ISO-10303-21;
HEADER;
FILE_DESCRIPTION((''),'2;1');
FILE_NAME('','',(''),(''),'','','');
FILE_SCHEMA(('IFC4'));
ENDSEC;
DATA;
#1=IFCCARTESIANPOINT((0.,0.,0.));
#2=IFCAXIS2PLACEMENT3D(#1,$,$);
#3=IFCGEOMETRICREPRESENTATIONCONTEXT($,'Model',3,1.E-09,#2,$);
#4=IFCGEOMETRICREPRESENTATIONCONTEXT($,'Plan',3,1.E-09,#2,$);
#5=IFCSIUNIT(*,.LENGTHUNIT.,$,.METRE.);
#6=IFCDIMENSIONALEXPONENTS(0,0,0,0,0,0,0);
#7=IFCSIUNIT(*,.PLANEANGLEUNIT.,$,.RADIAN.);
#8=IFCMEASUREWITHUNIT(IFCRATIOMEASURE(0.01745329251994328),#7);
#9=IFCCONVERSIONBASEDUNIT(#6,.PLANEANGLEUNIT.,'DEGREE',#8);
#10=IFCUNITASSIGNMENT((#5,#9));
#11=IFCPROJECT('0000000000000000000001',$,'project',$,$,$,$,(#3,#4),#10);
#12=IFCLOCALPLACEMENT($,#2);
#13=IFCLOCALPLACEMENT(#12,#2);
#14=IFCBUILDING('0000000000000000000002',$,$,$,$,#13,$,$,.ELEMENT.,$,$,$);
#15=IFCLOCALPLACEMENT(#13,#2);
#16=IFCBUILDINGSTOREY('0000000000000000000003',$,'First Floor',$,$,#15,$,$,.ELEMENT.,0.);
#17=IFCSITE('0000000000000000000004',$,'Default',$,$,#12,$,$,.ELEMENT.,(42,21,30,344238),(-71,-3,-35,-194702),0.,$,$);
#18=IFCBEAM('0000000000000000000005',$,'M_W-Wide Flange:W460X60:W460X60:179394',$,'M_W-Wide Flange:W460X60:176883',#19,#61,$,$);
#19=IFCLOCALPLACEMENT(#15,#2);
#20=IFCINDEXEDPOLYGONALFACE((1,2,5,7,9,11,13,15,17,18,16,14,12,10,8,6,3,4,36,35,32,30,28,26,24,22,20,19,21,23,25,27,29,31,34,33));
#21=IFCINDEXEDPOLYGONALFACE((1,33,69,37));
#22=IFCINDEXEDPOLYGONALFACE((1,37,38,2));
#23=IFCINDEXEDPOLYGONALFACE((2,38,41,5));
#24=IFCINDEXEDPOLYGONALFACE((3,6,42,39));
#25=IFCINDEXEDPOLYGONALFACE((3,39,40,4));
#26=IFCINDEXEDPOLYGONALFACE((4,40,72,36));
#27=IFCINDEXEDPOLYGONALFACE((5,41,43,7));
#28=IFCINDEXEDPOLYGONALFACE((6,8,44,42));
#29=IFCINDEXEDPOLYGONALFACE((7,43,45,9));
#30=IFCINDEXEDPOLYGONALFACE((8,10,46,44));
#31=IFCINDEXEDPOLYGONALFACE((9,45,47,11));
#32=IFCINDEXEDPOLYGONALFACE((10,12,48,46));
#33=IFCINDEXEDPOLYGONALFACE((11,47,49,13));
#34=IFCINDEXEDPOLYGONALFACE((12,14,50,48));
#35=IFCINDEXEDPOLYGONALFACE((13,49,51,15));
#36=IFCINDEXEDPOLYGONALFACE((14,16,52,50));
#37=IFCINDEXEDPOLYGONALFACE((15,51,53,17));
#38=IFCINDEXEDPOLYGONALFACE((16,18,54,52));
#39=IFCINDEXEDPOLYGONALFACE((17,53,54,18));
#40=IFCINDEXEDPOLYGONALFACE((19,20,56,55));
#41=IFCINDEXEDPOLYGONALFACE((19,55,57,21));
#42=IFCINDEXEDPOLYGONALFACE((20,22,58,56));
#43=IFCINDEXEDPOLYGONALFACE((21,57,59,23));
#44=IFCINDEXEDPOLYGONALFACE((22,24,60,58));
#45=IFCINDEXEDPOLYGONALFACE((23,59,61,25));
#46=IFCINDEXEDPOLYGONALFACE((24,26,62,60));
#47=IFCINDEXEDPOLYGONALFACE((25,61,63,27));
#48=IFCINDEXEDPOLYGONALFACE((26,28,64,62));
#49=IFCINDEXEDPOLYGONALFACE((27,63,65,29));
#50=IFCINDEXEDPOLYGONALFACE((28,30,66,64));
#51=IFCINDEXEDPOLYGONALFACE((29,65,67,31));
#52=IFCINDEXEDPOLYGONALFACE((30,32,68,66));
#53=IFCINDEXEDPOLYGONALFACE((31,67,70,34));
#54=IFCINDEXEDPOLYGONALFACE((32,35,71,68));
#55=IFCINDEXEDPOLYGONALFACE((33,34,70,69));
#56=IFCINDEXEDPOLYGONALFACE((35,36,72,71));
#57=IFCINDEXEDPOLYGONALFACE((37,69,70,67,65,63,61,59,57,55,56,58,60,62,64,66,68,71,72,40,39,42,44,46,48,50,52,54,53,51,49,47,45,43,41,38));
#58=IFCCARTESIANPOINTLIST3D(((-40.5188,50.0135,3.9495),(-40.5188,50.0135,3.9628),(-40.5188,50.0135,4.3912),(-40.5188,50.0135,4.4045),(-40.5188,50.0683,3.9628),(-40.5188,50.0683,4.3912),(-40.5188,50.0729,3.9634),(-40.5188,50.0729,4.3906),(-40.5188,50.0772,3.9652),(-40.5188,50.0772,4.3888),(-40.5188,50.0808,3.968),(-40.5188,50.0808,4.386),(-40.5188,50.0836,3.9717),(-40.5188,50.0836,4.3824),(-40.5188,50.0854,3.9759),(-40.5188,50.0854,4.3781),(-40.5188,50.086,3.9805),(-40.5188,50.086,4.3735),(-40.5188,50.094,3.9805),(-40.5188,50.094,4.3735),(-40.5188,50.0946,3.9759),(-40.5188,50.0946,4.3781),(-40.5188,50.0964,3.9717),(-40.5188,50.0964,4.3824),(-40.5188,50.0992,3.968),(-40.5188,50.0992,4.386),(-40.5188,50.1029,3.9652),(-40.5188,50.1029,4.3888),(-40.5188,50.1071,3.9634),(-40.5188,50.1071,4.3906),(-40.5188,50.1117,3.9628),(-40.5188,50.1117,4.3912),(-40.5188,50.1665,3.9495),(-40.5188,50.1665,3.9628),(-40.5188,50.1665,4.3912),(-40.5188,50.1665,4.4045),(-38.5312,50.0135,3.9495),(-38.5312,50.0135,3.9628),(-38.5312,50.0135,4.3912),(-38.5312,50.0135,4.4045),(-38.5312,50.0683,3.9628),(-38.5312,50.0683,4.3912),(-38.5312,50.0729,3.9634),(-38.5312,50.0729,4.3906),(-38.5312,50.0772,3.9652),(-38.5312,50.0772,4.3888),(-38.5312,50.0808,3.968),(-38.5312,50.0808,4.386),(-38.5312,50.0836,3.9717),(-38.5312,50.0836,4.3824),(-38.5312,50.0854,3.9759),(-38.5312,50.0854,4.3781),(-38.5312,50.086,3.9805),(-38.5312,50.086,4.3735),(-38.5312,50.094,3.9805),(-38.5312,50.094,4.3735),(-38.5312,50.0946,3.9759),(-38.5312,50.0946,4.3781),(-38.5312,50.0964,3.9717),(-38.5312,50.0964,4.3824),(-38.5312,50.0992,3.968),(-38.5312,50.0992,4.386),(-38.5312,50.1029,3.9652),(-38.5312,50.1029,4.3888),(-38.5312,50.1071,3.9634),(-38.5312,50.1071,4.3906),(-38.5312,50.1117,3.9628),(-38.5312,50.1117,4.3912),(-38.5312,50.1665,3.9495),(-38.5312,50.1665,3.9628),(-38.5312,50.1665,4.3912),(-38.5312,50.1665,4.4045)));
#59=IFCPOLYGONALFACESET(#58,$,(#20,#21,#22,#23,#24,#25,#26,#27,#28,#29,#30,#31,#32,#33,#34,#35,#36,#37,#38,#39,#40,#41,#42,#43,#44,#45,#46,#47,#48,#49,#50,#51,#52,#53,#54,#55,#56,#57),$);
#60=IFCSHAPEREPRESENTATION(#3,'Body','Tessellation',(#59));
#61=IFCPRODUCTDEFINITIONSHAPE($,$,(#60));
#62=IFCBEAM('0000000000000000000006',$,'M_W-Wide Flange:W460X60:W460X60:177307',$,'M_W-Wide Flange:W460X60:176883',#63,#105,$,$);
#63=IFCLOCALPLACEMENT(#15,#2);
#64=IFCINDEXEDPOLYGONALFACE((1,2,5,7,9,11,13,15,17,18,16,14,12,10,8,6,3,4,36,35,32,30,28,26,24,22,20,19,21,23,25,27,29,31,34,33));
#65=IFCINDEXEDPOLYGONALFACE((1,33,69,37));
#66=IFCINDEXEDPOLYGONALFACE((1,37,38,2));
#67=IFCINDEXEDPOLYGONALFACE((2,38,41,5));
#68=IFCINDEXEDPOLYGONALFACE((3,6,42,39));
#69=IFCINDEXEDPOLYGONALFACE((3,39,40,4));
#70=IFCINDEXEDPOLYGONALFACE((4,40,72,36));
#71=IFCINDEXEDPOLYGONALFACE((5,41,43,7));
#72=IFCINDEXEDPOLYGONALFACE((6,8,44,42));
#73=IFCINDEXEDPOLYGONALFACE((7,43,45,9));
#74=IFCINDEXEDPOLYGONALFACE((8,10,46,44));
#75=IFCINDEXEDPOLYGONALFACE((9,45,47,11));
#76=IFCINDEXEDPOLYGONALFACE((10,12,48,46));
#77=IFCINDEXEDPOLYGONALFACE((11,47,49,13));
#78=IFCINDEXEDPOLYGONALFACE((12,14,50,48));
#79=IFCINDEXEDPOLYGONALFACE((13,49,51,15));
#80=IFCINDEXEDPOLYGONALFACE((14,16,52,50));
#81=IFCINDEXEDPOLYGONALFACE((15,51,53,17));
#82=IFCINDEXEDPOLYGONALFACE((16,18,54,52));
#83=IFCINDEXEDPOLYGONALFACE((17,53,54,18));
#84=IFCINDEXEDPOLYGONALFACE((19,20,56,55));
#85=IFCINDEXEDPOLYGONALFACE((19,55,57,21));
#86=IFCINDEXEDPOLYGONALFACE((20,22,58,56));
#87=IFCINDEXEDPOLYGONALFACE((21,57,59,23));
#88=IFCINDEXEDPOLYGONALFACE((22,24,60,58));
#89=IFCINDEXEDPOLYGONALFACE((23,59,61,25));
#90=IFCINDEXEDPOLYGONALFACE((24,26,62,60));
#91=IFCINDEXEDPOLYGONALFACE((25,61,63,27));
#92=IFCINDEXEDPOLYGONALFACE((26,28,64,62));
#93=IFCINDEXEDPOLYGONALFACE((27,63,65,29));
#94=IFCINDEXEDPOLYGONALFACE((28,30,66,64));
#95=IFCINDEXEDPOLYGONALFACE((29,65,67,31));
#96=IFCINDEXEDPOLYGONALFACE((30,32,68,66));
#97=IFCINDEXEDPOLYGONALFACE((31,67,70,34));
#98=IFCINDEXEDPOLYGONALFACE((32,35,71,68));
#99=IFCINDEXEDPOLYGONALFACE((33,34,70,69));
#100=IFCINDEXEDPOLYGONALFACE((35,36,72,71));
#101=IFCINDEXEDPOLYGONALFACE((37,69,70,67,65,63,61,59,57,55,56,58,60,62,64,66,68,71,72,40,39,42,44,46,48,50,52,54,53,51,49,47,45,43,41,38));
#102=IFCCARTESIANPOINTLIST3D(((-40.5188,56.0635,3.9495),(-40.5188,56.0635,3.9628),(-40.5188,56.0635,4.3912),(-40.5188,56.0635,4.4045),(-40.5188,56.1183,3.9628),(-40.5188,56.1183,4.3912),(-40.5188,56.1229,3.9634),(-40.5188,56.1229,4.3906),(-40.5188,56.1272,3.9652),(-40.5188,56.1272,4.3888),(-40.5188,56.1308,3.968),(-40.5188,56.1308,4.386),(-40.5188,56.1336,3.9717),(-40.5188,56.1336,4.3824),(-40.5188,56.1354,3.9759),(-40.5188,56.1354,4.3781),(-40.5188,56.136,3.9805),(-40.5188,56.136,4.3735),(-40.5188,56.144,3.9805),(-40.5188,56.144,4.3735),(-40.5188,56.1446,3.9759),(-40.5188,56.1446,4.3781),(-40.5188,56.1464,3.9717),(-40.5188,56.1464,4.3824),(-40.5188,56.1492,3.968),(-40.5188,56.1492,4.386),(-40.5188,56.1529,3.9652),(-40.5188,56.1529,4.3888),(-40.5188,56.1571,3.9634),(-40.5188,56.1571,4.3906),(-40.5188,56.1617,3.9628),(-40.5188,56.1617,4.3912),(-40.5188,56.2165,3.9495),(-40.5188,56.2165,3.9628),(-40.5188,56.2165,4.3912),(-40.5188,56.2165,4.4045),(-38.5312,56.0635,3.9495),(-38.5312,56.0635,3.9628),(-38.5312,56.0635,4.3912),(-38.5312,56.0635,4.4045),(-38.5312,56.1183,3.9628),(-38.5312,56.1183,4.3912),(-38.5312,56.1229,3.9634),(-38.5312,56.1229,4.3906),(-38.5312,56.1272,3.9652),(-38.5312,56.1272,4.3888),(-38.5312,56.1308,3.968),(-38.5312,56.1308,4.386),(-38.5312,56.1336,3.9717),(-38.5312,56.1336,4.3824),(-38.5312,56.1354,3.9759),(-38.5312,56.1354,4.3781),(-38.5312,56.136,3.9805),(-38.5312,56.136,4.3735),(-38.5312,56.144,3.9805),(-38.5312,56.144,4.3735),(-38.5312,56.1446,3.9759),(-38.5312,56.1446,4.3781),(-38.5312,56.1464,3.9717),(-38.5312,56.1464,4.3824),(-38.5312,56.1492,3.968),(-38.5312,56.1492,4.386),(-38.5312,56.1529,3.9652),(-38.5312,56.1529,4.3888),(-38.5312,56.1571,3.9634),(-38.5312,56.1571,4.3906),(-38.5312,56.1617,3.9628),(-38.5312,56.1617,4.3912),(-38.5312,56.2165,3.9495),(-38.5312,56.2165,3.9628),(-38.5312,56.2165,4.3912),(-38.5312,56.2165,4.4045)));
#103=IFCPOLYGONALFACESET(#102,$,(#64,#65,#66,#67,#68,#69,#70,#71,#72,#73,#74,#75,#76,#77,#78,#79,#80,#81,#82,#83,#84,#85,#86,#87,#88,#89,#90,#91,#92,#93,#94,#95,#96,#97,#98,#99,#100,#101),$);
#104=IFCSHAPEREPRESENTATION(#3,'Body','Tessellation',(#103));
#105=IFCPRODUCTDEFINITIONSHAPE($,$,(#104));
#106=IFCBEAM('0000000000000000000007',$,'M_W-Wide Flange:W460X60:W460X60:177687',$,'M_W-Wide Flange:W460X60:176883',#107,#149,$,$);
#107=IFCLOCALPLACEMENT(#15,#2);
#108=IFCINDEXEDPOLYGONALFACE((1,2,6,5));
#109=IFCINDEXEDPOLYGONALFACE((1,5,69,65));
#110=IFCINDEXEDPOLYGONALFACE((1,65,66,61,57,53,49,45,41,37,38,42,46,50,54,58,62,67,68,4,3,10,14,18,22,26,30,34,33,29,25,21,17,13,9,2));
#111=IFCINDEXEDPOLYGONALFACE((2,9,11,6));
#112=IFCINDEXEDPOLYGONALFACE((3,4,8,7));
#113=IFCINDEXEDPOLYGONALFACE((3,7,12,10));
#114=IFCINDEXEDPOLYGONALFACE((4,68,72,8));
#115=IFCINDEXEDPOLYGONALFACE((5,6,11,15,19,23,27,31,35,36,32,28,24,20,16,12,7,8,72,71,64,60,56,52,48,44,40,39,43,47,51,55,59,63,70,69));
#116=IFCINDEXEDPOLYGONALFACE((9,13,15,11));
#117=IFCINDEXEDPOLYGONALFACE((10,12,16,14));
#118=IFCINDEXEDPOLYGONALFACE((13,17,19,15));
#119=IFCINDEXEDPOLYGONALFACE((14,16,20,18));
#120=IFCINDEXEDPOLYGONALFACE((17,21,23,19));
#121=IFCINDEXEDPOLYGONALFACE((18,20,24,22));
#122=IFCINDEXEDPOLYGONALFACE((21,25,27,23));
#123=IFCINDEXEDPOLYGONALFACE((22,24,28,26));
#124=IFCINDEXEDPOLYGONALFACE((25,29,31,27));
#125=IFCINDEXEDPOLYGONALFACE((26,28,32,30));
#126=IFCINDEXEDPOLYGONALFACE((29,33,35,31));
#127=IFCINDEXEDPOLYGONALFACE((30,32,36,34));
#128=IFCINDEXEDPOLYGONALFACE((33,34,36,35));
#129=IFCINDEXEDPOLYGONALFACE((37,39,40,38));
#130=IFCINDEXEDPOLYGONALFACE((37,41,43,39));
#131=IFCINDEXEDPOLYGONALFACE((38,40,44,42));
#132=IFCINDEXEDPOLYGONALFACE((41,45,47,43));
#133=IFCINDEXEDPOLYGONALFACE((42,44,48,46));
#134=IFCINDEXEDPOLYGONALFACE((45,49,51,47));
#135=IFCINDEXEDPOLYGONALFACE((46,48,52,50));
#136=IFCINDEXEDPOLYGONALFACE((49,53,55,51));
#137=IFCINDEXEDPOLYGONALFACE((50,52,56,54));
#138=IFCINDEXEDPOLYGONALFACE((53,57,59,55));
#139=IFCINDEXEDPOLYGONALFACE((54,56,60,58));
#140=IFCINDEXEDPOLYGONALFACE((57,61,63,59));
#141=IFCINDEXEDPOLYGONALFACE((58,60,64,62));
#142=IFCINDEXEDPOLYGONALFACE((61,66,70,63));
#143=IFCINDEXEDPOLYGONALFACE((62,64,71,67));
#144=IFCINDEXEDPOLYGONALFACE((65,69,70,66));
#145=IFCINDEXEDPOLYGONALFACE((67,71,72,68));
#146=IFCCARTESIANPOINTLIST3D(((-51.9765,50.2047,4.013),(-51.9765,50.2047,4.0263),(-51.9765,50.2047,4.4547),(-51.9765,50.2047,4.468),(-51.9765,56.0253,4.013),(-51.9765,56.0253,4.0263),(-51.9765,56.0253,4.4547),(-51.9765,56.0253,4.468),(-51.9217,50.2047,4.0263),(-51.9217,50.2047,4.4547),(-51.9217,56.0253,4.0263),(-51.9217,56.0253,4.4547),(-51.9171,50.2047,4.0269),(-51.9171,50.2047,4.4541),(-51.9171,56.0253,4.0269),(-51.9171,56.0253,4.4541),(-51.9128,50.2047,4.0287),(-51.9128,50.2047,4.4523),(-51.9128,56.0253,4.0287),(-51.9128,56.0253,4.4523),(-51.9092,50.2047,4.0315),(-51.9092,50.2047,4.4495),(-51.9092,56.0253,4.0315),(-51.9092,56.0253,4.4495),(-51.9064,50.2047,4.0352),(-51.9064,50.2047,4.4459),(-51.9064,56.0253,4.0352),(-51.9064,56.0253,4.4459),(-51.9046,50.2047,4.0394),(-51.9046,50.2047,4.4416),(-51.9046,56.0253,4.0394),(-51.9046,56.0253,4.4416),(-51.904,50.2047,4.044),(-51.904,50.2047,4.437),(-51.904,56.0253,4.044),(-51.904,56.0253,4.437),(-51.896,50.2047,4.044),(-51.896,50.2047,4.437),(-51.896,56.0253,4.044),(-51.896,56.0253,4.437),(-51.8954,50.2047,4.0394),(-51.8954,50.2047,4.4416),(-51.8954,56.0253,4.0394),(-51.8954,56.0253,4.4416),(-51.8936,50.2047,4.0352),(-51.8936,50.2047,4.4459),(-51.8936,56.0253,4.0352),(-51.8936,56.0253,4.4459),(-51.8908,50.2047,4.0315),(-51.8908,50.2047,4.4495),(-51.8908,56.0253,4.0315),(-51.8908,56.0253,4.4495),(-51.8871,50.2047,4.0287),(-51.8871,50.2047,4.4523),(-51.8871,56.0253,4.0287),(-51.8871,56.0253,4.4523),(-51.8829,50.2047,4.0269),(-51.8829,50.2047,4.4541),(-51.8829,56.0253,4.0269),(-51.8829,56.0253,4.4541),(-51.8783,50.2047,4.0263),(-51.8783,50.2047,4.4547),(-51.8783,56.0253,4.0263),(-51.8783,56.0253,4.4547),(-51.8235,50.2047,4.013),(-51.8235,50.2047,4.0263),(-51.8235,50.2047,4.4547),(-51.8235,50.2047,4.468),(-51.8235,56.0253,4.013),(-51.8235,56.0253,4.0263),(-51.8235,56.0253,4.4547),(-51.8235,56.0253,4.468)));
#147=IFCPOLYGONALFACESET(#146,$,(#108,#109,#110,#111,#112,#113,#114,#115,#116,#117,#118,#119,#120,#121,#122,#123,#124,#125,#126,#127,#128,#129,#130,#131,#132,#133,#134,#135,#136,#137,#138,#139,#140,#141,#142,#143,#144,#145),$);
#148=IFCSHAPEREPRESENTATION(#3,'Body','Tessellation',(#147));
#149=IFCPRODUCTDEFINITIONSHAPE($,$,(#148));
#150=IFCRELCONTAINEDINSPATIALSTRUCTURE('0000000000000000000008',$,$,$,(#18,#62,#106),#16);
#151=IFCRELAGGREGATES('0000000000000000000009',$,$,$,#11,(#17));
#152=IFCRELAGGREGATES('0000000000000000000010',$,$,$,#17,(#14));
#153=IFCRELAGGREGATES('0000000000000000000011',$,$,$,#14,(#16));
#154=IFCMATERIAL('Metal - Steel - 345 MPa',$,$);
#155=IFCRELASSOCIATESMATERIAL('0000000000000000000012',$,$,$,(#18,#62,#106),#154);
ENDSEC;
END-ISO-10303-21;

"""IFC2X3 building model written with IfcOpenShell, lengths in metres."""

from ifc_helpers import new_model, entity, si_unit, converted_unit, frame, frame_2d, origin, place, context, project, spatial, polyline, circle_curve, parameter, trimmed, segment, composite_curve, outline, extrude, material, element, save


model = new_model("IFC2X3")

# Units and contexts
model_context = context("Model", 3, precision=1e-09, world=origin())
plan_context = context("Plan", 3, precision=1e-09, world=origin())
ifc_project = project(units=[si_unit("LENGTHUNIT", "METRE"), converted_unit("PLANEANGLEUNIT", "DEGREE", entity("IfcRatioMeasure", 0.01745329251994328), si_unit("PLANEANGLEUNIT", "RADIAN"), dimensions=[0, 0, 0, 0, 0, 0, 0])], contexts=[model_context, plan_context])

# Site, building, storey
site_placement = place(None, origin())
site = spatial("IfcSite", under=ifc_project, at=site_placement, Name="Default", CompositionType="ELEMENT", RefLatitude=(42, 21, 30, 344238), RefLongitude=(-71, -3, -35, -194702), RefElevation=0.0)
building_placement = place(site_placement, origin())
building = spatial("IfcBuilding", under=site, at=building_placement, CompositionType="ELEMENT")
storey_placement = place(building_placement, origin())
storey = spatial("IfcBuildingStorey", under=building, at=storey_placement, Name="First Floor", CompositionType="ELEMENT", Elevation=0.0)

# Beams
ifc_material = material(Name="Metal - Steel - 345 MPa")
beam_1_placement = place(storey_placement, frame((-40.666, 50.09, 4.4045), z_axis=(0.0, 0.0, 1.0), x_axis=(0.0, -1.0, 0.0)))
element("IfcBeam", 1, at=beam_1_placement, inside=storey, material=ifc_material, Name="M_W-Wide Flange:W460X60:W460X60:179394", ObjectType="M_W-Wide Flange:W460X60:176883", context=model_context, shape_type="SweptSolid", body=[
    extrude(outline(composite_curve([segment(polyline([(-0.0765, -0.2142), (-0.0765, -0.2275)]), True, "CONTINUOUS"), segment(polyline([(-0.0765, -0.2275), (0.0765, -0.2275)]), True, "CONTINUOUS"), segment(polyline([(0.0765, -0.2275), (0.0765, -0.2142)]), True, "CONTINUOUS"), segment(polyline([(0.0765, -0.2142), (0.0217, -0.2142)]), True, "CONTINUOUS"), segment(trimmed(circle_curve(frame_2d((0.0217, -0.1965), x_axis=(0.0, -1.0)), 0.0177), [parameter(270.0)], [parameter(360.0)], True, "PARAMETER"), False, "CONTINUOUS"), segment(polyline([(0.004, -0.1965), (0.004, 0.1965)]), True, "CONTINUOUS"), segment(trimmed(circle_curve(frame_2d((0.0217, 0.1965), x_axis=(-1.0, 0.0)), 0.0177), [parameter(270.0)], [parameter(360.0)], True, "PARAMETER"), False, "CONTINUOUS"), segment(polyline([(0.0217, 0.2142), (0.0765, 0.2142)]), True, "CONTINUOUS"), segment(polyline([(0.0765, 0.2142), (0.0765, 0.2275)]), True, "CONTINUOUS"), segment(polyline([(0.0765, 0.2275), (-0.0765, 0.2275)]), True, "CONTINUOUS"), segment(polyline([(-0.0765, 0.2275), (-0.0765, 0.2142)]), True, "CONTINUOUS"), segment(polyline([(-0.0765, 0.2142), (-0.0217, 0.2142)]), True, "CONTINUOUS"), segment(trimmed(circle_curve(frame_2d((-0.0217, 0.1965), x_axis=(0.0, 1.0)), 0.0177), [parameter(270.0)], [parameter(360.0)], True, "PARAMETER"), False, "CONTINUOUS"), segment(polyline([(-0.004, 0.1965), (-0.004, -0.1965)]), True, "CONTINUOUS"), segment(trimmed(circle_curve(frame_2d((-0.0217, -0.1965), x_axis=(1.0, 0.0)), 0.0177), [parameter(270.0)], [parameter(0.0)], True, "PARAMETER"), False, "CONTINUOUS"), segment(polyline([(-0.0217, -0.2142), (-0.0765, -0.2142)]), True, "CONTINUOUS")], self_intersect=False)), frame((0.0, 0.1472, -0.2275), z_axis=(0.0, -1.0, 0.0), x_axis=(1.0, 0.0, 0.0)), (0.0, 0.0, -1.0), 1.9876),
])
beam_2_placement = place(storey_placement, frame((-40.654, 56.14, 4.4045), z_axis=(0.0, 0.0, 1.0), x_axis=(0.0, -1.0, 0.0)))
element("IfcBeam", 2, at=beam_2_placement, inside=storey, material=ifc_material, Name="M_W-Wide Flange:W460X60:W460X60:177307", ObjectType="M_W-Wide Flange:W460X60:176883", context=model_context, shape_type="SweptSolid", body=[
    extrude(outline(composite_curve([segment(polyline([(-0.0765, -0.2142), (-0.0765, -0.2275)]), True, "CONTINUOUS"), segment(polyline([(-0.0765, -0.2275), (0.0765, -0.2275)]), True, "CONTINUOUS"), segment(polyline([(0.0765, -0.2275), (0.0765, -0.2142)]), True, "CONTINUOUS"), segment(polyline([(0.0765, -0.2142), (0.0217, -0.2142)]), True, "CONTINUOUS"), segment(trimmed(circle_curve(frame_2d((0.0217, -0.1965), x_axis=(0.0, -1.0)), 0.0177), [parameter(270.0)], [parameter(360.0)], True, "PARAMETER"), False, "CONTINUOUS"), segment(polyline([(0.004, -0.1965), (0.004, 0.1965)]), True, "CONTINUOUS"), segment(trimmed(circle_curve(frame_2d((0.0217, 0.1965), x_axis=(-1.0, 0.0)), 0.0177), [parameter(270.0)], [parameter(360.0)], True, "PARAMETER"), False, "CONTINUOUS"), segment(polyline([(0.0217, 0.2142), (0.0765, 0.2142)]), True, "CONTINUOUS"), segment(polyline([(0.0765, 0.2142), (0.0765, 0.2275)]), True, "CONTINUOUS"), segment(polyline([(0.0765, 0.2275), (-0.0765, 0.2275)]), True, "CONTINUOUS"), segment(polyline([(-0.0765, 0.2275), (-0.0765, 0.2142)]), True, "CONTINUOUS"), segment(polyline([(-0.0765, 0.2142), (-0.0217, 0.2142)]), True, "CONTINUOUS"), segment(trimmed(circle_curve(frame_2d((-0.0217, 0.1965), x_axis=(0.0, 1.0)), 0.0177), [parameter(270.0)], [parameter(360.0)], True, "PARAMETER"), False, "CONTINUOUS"), segment(polyline([(-0.004, 0.1965), (-0.004, -0.1965)]), True, "CONTINUOUS"), segment(trimmed(circle_curve(frame_2d((-0.0217, -0.1965), x_axis=(1.0, 0.0)), 0.0177), [parameter(270.0)], [parameter(0.0)], True, "PARAMETER"), False, "CONTINUOUS"), segment(polyline([(-0.0217, -0.2142), (-0.0765, -0.2142)]), True, "CONTINUOUS")], self_intersect=False)), frame((0.0, 0.1352, -0.2275), z_axis=(0.0, -1.0, 0.0), x_axis=(1.0, 0.0, 0.0)), (0.0, 0.0, -1.0), 1.9876),
])
beam_3_placement = place(storey_placement, frame((-51.9, 56.1423, 4.468), z_axis=(0.0, 0.0, 1.0), x_axis=(-1.0, 0.0, 0.0)))
element("IfcBeam", 3, at=beam_3_placement, inside=storey, material=ifc_material, Name="M_W-Wide Flange:W460X60:W460X60:177687", ObjectType="M_W-Wide Flange:W460X60:176883", context=model_context, shape_type="SweptSolid", body=[
    extrude(outline(composite_curve([segment(polyline([(0.2142, -0.0765), (0.2275, -0.0765)]), True, "CONTINUOUS"), segment(polyline([(0.2275, -0.0765), (0.2275, 0.0765)]), True, "CONTINUOUS"), segment(polyline([(0.2275, 0.0765), (0.2142, 0.0765)]), True, "CONTINUOUS"), segment(polyline([(0.2142, 0.0765), (0.2142, 0.0217)]), True, "CONTINUOUS"), segment(trimmed(circle_curve(frame_2d((0.1965, 0.0217), x_axis=(0.0, 1.0)), 0.0177), [parameter(180.0)], [parameter(270.0)], True, "PARAMETER"), False, "CONTINUOUS"), segment(polyline([(0.1965, 0.004), (-0.1965, 0.004)]), True, "CONTINUOUS"), segment(trimmed(circle_curve(frame_2d((-0.1965, 0.0217), x_axis=(0.0, 1.0)), 0.0177), [parameter(90.0)], [parameter(180.0)], True, "PARAMETER"), False, "CONTINUOUS"), segment(polyline([(-0.2142, 0.0217), (-0.2142, 0.0765)]), True, "CONTINUOUS"), segment(polyline([(-0.2142, 0.0765), (-0.2275, 0.0765)]), True, "CONTINUOUS"), segment(polyline([(-0.2275, 0.0765), (-0.2275, -0.0765)]), True, "CONTINUOUS"), segment(polyline([(-0.2275, -0.0765), (-0.2142, -0.0765)]), True, "CONTINUOUS"), segment(polyline([(-0.2142, -0.0765), (-0.2142, -0.0217)]), True, "CONTINUOUS"), segment(trimmed(circle_curve(frame_2d((-0.1965, -0.0217), x_axis=(0.0, 1.0)), 0.0177), [parameter(360.0)], [parameter(90.0)], True, "PARAMETER"), False, "CONTINUOUS"), segment(polyline([(-0.1965, -0.004), (0.1965, -0.004)]), True, "CONTINUOUS"), segment(trimmed(circle_curve(frame_2d((0.1965, -0.0217), x_axis=(0.0, 1.0)), 0.0177), [parameter(270.0)], [parameter(0.0)], True, "PARAMETER"), False, "CONTINUOUS"), segment(polyline([(0.2142, -0.0217), (0.2142, -0.0765)]), True, "CONTINUOUS")], self_intersect=False)), frame((0.0, 5.9376, -0.2275), z_axis=(0.0, -1.0, 0.0), x_axis=(0.0, 0.0, -1.0)), (0.0, 0.0, 1.0), 5.8206),
])

save(model, "model.ifc")
